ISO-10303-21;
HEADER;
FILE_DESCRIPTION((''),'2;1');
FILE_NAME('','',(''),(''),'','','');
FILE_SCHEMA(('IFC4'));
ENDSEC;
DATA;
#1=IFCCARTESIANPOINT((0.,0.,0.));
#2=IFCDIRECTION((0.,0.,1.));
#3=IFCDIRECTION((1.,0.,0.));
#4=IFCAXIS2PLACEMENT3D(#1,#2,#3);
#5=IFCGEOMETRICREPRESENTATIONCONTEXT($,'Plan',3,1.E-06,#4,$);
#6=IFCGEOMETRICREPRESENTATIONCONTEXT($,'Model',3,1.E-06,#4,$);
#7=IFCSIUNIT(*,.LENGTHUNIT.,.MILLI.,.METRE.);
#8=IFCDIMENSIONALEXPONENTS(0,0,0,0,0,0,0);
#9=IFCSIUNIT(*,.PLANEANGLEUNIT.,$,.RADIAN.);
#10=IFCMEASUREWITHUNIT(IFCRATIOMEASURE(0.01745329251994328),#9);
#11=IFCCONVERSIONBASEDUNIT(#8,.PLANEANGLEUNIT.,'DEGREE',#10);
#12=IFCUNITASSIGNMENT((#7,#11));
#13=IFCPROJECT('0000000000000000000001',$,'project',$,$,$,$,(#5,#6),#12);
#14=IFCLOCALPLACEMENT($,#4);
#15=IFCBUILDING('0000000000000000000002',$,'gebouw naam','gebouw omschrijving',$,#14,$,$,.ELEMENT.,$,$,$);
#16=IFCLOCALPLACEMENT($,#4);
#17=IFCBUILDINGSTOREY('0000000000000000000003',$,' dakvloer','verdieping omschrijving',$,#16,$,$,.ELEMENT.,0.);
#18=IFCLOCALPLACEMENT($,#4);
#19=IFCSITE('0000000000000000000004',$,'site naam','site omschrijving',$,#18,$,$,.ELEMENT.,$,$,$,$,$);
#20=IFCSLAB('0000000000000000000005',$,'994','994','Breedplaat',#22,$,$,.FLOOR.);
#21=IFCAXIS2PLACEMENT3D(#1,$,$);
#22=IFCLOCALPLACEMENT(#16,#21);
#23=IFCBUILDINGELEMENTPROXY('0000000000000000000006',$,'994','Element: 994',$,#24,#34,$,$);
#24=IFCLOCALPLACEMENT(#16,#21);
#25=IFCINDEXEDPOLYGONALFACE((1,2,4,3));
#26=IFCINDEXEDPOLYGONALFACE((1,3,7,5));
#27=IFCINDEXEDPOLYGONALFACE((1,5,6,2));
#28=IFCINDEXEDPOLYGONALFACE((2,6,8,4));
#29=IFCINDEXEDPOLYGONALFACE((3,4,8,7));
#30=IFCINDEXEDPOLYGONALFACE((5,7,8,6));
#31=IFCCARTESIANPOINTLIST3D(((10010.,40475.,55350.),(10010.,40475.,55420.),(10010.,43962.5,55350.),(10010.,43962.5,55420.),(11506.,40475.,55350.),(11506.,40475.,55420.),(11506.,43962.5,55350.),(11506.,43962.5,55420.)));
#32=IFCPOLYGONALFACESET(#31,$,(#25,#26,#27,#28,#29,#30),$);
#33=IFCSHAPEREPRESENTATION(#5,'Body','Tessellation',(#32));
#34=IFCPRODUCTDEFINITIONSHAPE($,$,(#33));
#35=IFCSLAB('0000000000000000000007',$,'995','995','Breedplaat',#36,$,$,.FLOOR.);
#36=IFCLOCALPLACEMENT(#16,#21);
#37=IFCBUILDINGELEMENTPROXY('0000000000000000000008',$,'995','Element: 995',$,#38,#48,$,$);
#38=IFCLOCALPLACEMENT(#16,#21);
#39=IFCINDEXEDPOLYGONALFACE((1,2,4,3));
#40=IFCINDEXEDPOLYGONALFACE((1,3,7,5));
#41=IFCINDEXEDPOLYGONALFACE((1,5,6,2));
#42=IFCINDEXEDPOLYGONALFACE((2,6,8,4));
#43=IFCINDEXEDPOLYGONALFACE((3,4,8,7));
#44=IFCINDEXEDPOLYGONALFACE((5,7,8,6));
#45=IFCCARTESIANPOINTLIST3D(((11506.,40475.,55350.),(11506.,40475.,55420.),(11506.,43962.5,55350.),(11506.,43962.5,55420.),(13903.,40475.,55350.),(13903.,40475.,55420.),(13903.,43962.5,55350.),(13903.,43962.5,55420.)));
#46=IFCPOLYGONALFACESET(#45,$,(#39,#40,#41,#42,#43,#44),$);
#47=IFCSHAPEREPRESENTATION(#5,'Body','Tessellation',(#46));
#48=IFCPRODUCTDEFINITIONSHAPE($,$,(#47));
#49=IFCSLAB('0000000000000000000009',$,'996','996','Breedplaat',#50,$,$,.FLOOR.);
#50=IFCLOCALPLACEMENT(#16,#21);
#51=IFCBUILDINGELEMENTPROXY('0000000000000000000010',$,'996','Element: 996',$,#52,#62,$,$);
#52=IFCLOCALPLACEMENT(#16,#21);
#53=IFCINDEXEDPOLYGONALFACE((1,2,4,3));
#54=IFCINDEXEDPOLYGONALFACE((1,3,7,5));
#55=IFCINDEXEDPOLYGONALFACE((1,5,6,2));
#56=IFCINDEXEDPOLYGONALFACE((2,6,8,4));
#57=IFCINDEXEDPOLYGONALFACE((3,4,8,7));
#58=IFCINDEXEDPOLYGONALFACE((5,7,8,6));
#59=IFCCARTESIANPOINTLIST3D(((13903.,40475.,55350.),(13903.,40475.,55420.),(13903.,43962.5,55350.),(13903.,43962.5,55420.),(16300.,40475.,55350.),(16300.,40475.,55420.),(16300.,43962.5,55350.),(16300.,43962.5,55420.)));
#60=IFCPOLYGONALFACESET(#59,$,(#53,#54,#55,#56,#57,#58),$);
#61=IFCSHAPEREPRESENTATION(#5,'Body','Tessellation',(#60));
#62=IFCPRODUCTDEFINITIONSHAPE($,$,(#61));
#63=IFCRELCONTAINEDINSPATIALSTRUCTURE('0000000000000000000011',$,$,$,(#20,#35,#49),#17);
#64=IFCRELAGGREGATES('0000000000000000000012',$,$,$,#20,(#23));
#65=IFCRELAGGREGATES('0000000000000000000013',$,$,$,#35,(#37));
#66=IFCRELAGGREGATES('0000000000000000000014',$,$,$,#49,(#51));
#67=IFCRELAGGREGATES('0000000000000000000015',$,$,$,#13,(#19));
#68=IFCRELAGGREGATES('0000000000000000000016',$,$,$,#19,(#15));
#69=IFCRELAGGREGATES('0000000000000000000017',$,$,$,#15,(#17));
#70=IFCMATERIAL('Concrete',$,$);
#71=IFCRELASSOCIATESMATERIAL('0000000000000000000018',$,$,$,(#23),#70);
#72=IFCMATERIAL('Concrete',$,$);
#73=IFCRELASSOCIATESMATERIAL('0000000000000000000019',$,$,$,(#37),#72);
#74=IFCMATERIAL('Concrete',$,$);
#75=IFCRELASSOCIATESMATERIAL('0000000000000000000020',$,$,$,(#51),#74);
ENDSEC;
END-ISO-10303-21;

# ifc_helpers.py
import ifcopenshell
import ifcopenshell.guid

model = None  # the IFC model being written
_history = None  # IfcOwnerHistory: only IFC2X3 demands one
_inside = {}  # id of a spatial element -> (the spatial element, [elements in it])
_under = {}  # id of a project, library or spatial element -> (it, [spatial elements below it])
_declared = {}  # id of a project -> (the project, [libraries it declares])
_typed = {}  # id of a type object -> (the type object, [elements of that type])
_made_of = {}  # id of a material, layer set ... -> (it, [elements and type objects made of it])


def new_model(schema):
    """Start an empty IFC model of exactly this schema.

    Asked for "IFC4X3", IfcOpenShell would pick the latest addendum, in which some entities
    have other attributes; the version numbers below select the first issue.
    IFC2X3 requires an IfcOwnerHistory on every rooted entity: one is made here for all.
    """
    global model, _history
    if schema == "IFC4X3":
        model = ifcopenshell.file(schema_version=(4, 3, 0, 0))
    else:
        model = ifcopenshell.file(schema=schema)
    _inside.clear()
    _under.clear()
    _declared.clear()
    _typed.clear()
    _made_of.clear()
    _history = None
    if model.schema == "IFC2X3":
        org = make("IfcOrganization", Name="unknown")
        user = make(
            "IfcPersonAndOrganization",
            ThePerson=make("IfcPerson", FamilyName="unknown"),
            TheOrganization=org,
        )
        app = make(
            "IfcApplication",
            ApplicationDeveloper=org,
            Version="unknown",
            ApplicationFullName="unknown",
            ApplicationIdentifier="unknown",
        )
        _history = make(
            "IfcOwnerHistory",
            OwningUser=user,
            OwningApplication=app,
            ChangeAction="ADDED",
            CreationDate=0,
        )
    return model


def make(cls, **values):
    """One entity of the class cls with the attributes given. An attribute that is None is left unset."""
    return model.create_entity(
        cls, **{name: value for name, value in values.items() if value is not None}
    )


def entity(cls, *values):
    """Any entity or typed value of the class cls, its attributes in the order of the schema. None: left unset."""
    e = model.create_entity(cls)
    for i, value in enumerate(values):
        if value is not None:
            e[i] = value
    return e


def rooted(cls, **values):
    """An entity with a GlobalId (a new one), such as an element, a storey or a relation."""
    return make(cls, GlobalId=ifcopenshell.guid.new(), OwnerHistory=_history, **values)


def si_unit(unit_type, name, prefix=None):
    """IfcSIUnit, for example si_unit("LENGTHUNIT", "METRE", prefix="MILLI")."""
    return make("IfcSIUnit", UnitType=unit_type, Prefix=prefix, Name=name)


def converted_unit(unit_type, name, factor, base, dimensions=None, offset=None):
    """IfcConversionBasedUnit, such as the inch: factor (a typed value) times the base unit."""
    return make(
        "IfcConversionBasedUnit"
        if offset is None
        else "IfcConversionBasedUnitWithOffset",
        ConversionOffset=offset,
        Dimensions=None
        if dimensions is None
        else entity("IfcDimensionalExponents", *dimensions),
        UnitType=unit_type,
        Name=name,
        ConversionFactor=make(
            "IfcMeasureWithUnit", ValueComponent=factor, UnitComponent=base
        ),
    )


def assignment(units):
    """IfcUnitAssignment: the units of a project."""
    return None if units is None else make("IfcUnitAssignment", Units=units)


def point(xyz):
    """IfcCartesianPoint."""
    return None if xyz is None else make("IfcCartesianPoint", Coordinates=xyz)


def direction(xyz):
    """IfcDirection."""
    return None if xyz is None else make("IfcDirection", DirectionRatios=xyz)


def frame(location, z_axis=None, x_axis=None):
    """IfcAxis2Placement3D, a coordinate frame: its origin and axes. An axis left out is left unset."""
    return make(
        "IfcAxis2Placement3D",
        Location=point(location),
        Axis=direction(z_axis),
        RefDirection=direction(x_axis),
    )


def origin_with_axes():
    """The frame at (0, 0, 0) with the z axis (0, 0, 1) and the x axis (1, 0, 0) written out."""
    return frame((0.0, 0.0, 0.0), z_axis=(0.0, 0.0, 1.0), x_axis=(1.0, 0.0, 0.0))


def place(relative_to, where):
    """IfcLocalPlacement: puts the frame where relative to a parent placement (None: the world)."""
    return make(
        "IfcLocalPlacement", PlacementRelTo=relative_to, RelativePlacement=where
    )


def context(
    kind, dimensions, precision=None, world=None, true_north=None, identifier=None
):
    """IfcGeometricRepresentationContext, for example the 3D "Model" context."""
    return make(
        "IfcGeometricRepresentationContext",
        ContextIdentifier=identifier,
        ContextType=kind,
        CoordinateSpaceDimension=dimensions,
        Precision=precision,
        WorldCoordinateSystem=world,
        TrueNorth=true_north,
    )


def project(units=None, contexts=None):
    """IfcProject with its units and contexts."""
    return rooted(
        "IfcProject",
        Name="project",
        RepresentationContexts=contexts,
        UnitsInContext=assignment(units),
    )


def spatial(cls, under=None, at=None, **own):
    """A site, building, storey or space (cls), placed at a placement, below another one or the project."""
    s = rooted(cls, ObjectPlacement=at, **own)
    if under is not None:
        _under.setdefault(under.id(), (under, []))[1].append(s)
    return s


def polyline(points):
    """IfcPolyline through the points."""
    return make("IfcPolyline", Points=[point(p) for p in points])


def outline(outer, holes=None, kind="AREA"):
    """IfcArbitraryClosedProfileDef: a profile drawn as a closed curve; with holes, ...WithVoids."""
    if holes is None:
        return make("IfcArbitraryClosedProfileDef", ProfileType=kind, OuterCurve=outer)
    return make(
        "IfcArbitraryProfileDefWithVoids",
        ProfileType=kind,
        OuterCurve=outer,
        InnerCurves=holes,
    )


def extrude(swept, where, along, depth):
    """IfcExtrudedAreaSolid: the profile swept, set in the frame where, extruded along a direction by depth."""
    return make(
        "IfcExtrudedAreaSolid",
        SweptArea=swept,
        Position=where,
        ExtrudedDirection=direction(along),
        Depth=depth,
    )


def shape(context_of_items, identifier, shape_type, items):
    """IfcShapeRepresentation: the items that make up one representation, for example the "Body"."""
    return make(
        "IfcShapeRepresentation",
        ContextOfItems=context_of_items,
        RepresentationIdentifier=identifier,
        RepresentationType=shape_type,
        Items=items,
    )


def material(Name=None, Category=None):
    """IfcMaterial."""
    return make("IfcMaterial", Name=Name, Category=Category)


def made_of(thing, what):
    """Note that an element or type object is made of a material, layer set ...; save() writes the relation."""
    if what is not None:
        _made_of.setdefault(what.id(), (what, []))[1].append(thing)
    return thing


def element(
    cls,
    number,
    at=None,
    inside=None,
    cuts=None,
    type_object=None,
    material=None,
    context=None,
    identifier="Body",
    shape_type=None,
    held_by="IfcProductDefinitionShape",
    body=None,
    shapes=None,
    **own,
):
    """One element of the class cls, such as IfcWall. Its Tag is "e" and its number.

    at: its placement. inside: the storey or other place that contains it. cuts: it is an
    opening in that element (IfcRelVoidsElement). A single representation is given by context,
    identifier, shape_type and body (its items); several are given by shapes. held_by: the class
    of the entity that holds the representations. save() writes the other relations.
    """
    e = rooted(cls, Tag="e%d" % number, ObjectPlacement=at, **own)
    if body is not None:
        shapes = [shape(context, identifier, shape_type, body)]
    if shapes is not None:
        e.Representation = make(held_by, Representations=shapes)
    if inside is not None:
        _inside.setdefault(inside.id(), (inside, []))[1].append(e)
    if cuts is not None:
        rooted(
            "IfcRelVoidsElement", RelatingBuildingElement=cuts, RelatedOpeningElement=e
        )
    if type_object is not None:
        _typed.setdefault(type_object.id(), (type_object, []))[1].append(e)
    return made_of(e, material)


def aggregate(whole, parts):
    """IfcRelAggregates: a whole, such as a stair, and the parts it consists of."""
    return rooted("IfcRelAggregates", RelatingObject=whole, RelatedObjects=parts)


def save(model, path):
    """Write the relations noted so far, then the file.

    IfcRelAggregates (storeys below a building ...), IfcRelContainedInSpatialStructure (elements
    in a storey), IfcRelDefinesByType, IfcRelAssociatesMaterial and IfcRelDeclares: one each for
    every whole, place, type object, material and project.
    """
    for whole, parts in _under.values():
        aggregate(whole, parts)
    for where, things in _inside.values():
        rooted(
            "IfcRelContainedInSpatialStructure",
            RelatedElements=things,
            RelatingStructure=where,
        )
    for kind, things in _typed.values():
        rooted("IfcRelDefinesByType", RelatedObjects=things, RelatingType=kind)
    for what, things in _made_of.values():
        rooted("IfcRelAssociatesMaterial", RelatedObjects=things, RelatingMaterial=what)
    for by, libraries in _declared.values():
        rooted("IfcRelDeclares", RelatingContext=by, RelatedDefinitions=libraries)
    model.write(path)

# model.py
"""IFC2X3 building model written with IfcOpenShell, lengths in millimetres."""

from ifc_helpers import new_model, entity, si_unit, converted_unit, frame, origin_with_axes, place, context, project, spatial, polyline, outline, extrude, material, element, aggregate, save


model = new_model("IFC2X3")

# Units and contexts
plan_context = context("Plan", 3, precision=1e-06, world=origin_with_axes())
model_context = context("Model", 3, precision=1e-06, world=origin_with_axes())
ifc_project = project(units=[si_unit("LENGTHUNIT", "METRE", prefix="MILLI"), converted_unit("PLANEANGLEUNIT", "DEGREE", entity("IfcRatioMeasure", 0.01745329251994328), si_unit("PLANEANGLEUNIT", "RADIAN"), dimensions=[0, 0, 0, 0, 0, 0, 0])], contexts=[plan_context, model_context])

# Site, building, storey
site_placement = place(None, origin_with_axes())
site = spatial("IfcSite", under=ifc_project, at=site_placement, Name="site naam", Description="site omschrijving", CompositionType="ELEMENT")
building_placement = place(None, origin_with_axes())
building = spatial("IfcBuilding", under=site, at=building_placement, Name="gebouw naam", Description="gebouw omschrijving", CompositionType="ELEMENT")
storey_placement = place(None, origin_with_axes())
storey = spatial("IfcBuildingStorey", under=building, at=storey_placement, Name=" dakvloer", Description="verdieping omschrijving", CompositionType="ELEMENT", Elevation=0.0)

# Slab, building element proxy, opening
slab_1_placement = place(None, frame((10010.0, 43962.5, 55350.0), z_axis=(0.0, 0.0, 1.0), x_axis=(0.0, -1.0, 0.0)))
slab_1 = element("IfcSlab", 1, at=slab_1_placement, inside=storey, Name="994", Description="994", ObjectType="Breedplaat", PredefinedType="FLOOR")
ifc_material_1 = material(Name="Concrete")
proxy_1_placement = place(slab_1_placement, origin_with_axes())
proxy_1 = element("IfcBuildingElementProxy", 2, at=proxy_1_placement, material=ifc_material_1, Name="994", Description="Element: 994", context=plan_context, shape_type="SweptSolid", body=[
    extrude(outline(polyline([(3487.5, 1496.0), (0.0, 1496.0), (0.0, 0.0), (3487.5, 0.0), (3487.5, 1496.0)])), origin_with_axes(), (0.0, 0.0, 1.0), 70.0),
])
opening_1_placement = place(None, frame((10010.0, 43962.5, 55350.0), z_axis=(0.0, 0.0, 1.0), x_axis=(0.0, -1.0, 0.0)))
element("IfcOpeningElement", 3, at=opening_1_placement, cuts=proxy_1, ObjectType="Opening", context=plan_context, shape_type="SweptSolid", body=[
    extrude(outline(polyline([(-0.1, -0.1), (-0.1, 10.0), (10.0, -0.1), (-0.1, -0.1)])), frame((3488.7, 1496.2, -0.1), z_axis=(-1.0, 0.0, 0.0), x_axis=(0.0, -1.0, 0.0)), (0.0, 0.0, 1.0), 3489.7),
])
aggregate(slab_1, [proxy_1])

# Slabs, building element proxies, openings
slab_2_placement = place(None, frame((11506.0, 43962.5, 55350.0), z_axis=(0.0, 0.0, 1.0), x_axis=(0.0, -1.0, 0.0)))
slab_2 = element("IfcSlab", 4, at=slab_2_placement, inside=storey, Name="995", Description="995", ObjectType="Breedplaat", PredefinedType="FLOOR")
ifc_material_2 = material(Name="Concrete")
proxy_2_placement = place(slab_2_placement, origin_with_axes())
proxy_2 = element("IfcBuildingElementProxy", 5, at=proxy_2_placement, material=ifc_material_2, Name="995", Description="Element: 995", context=plan_context, shape_type="SweptSolid", body=[
    extrude(outline(polyline([(0.0, 2397.0), (0.0, 0.0), (3487.5, 0.0), (3487.5, 2397.0), (0.0, 2397.0)])), origin_with_axes(), (0.0, 0.0, 1.0), 70.0),
])
opening_2_placement = place(None, frame((11506.0, 43962.5, 55350.0), z_axis=(0.0, 0.0, 1.0), x_axis=(0.0, -1.0, 0.0)))
element("IfcOpeningElement", 6, at=opening_2_placement, cuts=proxy_2, ObjectType="Opening", context=plan_context, shape_type="SweptSolid", body=[
    extrude(outline(polyline([(-0.1, -0.1), (-0.1, 10.0), (10.0, -0.1), (-0.1, -0.1)])), frame((-1.2, -0.1, -0.1), z_axis=(1.0, 0.0, 0.0), x_axis=(0.0, 1.0, 0.0)), (0.0, 0.0, 1.0), 3489.7),
])
opening_3_placement = place(None, frame((11506.0, 43962.5, 55350.0), z_axis=(0.0, 0.0, 1.0), x_axis=(0.0, -1.0, 0.0)))
element("IfcOpeningElement", 7, at=opening_3_placement, cuts=proxy_2, ObjectType="Opening", context=plan_context, shape_type="SweptSolid", body=[
    extrude(outline(polyline([(-0.1, -0.1), (-0.1, 10.0), (10.0, -0.1), (-0.1, -0.1)])), frame((3488.7, 2397.2, -0.1), z_axis=(-1.0, 0.0, 0.0), x_axis=(0.0, -1.0, 0.0)), (0.0, 0.0, 1.0), 3489.7),
])
aggregate(slab_2, [proxy_2])
slab_3_placement = place(None, frame((13903.0, 43962.5, 55350.0), z_axis=(0.0, 0.0, 1.0), x_axis=(0.0, -1.0, 0.0)))
slab_3 = element("IfcSlab", 8, at=slab_3_placement, inside=storey, Name="996", Description="996", ObjectType="Breedplaat", PredefinedType="FLOOR")
ifc_material_3 = material(Name="Concrete")
proxy_3_placement = place(slab_3_placement, origin_with_axes())
proxy_3 = element("IfcBuildingElementProxy", 9, at=proxy_3_placement, material=ifc_material_3, Name="996", Description="Element: 996", context=plan_context, shape_type="SweptSolid", body=[
    extrude(outline(polyline([(0.0, 2397.0), (0.0, 0.0), (3487.5, 0.0), (3487.5, 2397.0), (0.0, 2397.0)])), origin_with_axes(), (0.0, 0.0, 1.0), 70.0),
])
opening_4_placement = place(None, frame((13903.0, 43962.5, 55350.0), z_axis=(0.0, 0.0, 1.0), x_axis=(0.0, -1.0, 0.0)))
element("IfcOpeningElement", 10, at=opening_4_placement, cuts=proxy_3, ObjectType="Opening", context=plan_context, shape_type="SweptSolid", body=[
    extrude(outline(polyline([(-0.1, -0.1), (-0.1, 10.0), (10.0, -0.1), (-0.1, -0.1)])), frame((-1.2, -0.1, -0.1), z_axis=(1.0, 0.0, 0.0), x_axis=(0.0, 1.0, 0.0)), (0.0, 0.0, 1.0), 3489.7),
])
opening_5_placement = place(None, frame((13903.0, 43962.5, 55350.0), z_axis=(0.0, 0.0, 1.0), x_axis=(0.0, -1.0, 0.0)))
element("IfcOpeningElement", 11, at=opening_5_placement, cuts=proxy_3, ObjectType="Opening", context=plan_context, shape_type="SweptSolid", body=[
    extrude(outline(polyline([(-0.1, -0.1), (-0.1, 10.0), (10.0, -0.1), (-0.1, -0.1)])), frame((3488.7, 2397.2, -0.1), z_axis=(-1.0, 0.0, 0.0), x_axis=(0.0, -1.0, 0.0)), (0.0, 0.0, 1.0), 3489.7),
])
aggregate(slab_3, [proxy_3])

save(model, "model.ifc")
